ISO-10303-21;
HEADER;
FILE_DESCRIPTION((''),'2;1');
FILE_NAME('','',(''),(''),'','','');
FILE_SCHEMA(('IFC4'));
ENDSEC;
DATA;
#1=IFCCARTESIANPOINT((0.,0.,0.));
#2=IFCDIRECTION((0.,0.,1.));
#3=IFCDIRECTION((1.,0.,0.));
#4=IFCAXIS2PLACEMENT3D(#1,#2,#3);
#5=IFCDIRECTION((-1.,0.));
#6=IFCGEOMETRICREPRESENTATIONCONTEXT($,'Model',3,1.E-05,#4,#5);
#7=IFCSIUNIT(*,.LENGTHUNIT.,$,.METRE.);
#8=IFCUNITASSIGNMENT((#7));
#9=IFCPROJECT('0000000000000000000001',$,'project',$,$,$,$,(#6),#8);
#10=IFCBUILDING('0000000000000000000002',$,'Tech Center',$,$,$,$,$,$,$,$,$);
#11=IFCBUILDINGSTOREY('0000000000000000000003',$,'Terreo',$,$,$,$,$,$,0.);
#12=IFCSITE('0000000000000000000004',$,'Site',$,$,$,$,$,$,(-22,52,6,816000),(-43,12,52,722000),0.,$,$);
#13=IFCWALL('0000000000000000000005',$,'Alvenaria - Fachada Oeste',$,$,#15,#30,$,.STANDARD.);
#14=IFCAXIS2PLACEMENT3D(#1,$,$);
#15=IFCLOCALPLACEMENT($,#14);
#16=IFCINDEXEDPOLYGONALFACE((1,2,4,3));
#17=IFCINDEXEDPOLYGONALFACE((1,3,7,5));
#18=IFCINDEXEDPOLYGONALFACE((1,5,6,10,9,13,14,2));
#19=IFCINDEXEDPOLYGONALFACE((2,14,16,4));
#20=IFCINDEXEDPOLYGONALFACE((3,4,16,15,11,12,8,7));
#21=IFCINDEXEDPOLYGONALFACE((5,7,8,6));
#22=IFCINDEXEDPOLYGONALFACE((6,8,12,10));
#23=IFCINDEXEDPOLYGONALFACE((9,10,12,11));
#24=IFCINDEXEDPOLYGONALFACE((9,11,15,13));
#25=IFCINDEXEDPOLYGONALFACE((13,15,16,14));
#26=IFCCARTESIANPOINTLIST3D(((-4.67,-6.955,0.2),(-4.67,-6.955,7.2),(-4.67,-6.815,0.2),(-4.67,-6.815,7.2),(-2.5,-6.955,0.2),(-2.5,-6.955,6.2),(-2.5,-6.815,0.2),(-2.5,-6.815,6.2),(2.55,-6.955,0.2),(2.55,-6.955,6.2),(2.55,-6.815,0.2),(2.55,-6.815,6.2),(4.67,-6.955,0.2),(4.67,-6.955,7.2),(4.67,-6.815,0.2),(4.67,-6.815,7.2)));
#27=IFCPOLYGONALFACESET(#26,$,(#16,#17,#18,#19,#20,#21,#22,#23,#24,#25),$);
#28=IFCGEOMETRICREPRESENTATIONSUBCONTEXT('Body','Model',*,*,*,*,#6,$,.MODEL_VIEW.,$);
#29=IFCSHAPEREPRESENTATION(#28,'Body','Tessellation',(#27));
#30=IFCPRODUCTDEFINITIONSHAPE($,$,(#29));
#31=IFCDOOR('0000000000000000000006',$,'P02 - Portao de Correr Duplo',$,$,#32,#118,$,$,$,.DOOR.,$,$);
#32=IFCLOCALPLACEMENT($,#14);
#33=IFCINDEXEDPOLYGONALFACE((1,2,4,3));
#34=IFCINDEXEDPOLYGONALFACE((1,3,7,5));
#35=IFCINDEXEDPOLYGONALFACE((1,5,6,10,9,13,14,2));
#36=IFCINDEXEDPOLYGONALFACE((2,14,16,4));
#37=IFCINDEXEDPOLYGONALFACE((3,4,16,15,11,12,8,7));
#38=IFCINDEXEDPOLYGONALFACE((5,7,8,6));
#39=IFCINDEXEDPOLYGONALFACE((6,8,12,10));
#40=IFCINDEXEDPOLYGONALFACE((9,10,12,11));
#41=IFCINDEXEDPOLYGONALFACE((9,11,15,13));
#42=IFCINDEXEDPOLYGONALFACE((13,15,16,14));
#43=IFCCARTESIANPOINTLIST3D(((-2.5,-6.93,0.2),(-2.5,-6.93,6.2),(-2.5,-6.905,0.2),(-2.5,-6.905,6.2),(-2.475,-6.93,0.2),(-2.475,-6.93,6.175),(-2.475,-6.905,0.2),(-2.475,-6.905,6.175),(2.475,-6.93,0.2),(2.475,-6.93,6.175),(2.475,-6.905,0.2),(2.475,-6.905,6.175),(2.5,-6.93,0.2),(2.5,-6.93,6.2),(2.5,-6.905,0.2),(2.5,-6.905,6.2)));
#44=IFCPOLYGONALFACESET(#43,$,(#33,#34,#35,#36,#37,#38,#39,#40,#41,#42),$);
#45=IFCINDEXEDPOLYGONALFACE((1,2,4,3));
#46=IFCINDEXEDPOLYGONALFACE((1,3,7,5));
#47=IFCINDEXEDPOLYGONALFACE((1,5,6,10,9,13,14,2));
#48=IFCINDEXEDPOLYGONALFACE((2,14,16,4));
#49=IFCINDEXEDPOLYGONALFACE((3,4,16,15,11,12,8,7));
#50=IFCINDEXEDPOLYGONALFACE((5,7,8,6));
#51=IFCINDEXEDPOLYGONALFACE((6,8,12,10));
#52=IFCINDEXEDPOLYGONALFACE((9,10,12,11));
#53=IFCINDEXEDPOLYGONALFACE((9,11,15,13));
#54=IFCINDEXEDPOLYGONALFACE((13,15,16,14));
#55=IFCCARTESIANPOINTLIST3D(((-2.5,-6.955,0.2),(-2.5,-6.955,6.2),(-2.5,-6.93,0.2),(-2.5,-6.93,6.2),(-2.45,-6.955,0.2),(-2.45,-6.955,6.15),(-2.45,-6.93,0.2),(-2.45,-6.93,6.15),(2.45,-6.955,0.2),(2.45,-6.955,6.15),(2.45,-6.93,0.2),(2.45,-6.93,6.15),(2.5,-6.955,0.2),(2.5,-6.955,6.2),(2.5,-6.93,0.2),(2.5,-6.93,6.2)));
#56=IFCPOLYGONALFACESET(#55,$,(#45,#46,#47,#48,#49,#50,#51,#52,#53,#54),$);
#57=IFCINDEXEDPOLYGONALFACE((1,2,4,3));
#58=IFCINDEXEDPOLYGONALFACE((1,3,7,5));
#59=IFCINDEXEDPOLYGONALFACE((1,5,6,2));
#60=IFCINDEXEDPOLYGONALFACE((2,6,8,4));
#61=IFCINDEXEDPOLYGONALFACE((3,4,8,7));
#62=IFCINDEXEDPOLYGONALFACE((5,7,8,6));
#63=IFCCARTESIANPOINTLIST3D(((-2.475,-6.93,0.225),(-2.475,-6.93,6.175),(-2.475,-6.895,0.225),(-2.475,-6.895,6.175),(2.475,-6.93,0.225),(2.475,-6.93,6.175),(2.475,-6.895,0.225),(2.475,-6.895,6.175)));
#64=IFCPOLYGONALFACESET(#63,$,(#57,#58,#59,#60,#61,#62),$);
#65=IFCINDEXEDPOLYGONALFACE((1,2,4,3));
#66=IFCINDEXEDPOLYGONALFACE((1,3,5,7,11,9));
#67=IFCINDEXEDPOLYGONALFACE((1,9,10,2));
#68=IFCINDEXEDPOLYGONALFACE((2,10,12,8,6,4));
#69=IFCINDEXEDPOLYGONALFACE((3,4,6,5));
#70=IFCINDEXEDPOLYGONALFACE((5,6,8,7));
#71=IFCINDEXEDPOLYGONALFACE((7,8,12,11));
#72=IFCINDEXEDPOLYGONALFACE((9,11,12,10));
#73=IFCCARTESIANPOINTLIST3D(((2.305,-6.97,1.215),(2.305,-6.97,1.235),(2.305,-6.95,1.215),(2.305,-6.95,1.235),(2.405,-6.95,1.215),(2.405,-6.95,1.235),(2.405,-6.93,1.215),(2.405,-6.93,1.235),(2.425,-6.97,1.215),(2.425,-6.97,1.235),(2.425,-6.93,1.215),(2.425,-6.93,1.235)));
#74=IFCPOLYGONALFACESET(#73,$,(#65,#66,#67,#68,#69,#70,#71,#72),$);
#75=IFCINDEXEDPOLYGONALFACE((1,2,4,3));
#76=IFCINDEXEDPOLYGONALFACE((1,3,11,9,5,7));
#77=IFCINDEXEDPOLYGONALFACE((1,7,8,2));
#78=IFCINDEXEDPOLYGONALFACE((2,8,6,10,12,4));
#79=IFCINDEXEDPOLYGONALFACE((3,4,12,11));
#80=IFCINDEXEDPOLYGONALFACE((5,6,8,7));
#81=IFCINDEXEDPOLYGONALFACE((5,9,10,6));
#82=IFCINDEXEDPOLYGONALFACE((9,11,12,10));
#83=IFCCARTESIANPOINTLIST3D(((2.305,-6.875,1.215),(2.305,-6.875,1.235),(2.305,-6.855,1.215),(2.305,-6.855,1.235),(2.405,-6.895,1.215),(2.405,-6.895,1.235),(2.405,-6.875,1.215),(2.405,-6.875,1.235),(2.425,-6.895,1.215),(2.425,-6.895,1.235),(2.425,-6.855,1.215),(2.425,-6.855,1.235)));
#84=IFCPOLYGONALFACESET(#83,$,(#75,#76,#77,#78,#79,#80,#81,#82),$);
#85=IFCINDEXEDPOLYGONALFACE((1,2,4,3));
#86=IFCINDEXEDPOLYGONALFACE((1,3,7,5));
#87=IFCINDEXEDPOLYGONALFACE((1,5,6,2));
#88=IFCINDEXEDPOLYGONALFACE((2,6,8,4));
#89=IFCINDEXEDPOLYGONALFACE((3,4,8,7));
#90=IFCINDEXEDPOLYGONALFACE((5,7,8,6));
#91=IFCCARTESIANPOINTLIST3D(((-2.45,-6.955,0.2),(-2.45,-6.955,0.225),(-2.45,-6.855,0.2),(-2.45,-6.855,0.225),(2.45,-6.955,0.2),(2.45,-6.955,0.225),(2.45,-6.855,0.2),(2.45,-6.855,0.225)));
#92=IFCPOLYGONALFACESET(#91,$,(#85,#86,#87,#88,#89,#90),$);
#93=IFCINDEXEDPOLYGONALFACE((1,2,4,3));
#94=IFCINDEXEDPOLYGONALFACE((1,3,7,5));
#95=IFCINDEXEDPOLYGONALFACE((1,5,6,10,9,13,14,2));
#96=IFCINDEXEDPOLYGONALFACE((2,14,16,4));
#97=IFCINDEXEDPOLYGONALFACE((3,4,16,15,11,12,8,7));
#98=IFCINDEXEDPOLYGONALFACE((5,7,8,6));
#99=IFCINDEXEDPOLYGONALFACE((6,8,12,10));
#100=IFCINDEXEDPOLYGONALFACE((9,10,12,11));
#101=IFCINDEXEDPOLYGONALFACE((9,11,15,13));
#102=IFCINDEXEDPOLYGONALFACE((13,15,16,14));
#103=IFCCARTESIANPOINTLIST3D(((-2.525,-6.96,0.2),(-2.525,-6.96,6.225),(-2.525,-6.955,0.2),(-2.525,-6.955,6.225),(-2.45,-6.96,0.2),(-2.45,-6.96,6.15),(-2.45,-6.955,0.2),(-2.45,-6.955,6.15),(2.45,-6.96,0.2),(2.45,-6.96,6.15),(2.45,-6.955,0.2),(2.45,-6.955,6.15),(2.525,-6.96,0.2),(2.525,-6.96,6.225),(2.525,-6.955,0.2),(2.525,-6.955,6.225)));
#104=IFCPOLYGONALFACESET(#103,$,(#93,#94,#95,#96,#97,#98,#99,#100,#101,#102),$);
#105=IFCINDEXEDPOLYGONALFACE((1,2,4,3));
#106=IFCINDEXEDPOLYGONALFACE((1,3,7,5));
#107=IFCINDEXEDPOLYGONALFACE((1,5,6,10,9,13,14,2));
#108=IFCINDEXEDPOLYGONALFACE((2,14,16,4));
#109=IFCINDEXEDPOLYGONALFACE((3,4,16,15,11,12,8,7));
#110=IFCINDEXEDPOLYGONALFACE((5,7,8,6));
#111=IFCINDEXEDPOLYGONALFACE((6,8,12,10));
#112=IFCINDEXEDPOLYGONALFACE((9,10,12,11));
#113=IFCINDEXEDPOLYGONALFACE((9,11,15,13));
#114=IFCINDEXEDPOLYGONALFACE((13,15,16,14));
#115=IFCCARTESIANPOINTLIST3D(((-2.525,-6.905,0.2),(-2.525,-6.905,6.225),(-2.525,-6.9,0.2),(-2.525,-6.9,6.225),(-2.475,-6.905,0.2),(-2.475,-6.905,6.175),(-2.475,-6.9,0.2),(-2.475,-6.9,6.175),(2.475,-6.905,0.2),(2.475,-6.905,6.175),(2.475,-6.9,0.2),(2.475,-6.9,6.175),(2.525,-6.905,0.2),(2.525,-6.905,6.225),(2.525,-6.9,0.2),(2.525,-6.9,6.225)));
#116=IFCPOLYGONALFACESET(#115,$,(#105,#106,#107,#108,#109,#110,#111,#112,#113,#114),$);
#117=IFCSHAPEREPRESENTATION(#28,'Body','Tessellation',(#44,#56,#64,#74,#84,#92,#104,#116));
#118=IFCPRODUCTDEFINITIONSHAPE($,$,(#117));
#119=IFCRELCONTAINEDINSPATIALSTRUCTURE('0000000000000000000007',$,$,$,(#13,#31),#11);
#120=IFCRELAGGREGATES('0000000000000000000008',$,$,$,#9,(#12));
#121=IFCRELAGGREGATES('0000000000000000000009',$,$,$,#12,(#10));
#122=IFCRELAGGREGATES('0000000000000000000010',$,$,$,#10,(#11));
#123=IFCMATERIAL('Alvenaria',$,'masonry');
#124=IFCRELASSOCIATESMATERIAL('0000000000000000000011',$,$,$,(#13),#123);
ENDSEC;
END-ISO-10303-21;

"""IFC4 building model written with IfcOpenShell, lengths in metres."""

from ifc_helpers import new_model, si_unit, direction, frame, origin_with_axes, place, context, subcontext, project, spatial, line, indexed_curve, outline, extrude, material, element, fill, save


model = new_model("IFC4")

# Units and contexts
model_context = context("Model", 3, precision=1e-05, world=origin_with_axes(), true_north=direction((-1.0, 0.0)))
body_context = subcontext(model_context, "Body", "Model", "MODEL_VIEW")
ifc_project = project(units=[si_unit("LENGTHUNIT", "METRE")], contexts=[model_context])

# Site, building, storey
site = spatial("IfcSite", under=ifc_project, Name="Site", RefLatitude=(-22, 52, 6, 816000), RefLongitude=(-43, 12, 52, 722000), RefElevation=0.0)
building = spatial("IfcBuilding", under=site, Name="Tech Center")
storey = spatial("IfcBuildingStorey", under=building, Name="Terreo", Elevation=0.0)

# Wall, opening, door
ifc_material_1 = material(Name="Alvenaria", Category="masonry")
wall_1_placement = place(None, frame((-4.67, -6.955, 0.2), z_axis=(0.0, 0.0, 1.0), x_axis=(1.0, 0.0, 0.0)))
wall_1 = element("IfcWall", 1, at=wall_1_placement, inside=storey, material=ifc_material_1, Name="Alvenaria - Fachada Oeste", PredefinedType="STANDARD", context=body_context, shape_type="SweptSolid", body=[
    extrude(outline(indexed_curve([(0.0, 0.0), (0.0, 0.14), (9.34, 0.14), (9.34, 0.0), (0.0, 0.0)], self_intersect=False)), origin_with_axes(), (0.0, 0.0, 1.0), 7.0),
])
opening_1_placement = place(wall_1_placement, frame((2.17, 0.0, 0.0), z_axis=(0.0, 0.0, 1.0), x_axis=(1.0, 0.0, 0.0)))
opening_1 = element("IfcOpeningElement", 2, at=opening_1_placement, cuts=wall_1, context=body_context, shape_type="SweptSolid", body=[
    extrude(outline(indexed_curve([(0.0, 0.0), (0.0, 0.34), (5.05, 0.34), (5.05, 0.0), (0.0, 0.0)], self_intersect=False)), origin_with_axes(), (0.0, 0.0, 1.0), 6.0),
])
door_1_placement = place(None, frame((-2.5, -6.955, 0.2), z_axis=(0.0, 0.0, 1.0), x_axis=(1.0, 0.0, 0.0)))
door_1 = element("IfcDoor", 3, at=door_1_placement, inside=storey, Name="P02 - Portao de Correr Duplo", PredefinedType="DOOR", context=body_context, shape_type="SweptSolid", body=[
    extrude(outline(indexed_curve([(0.0, 0.0), (0.0, 6.0), (5.0, 6.0), (5.0, 0.0), (4.975, 0.0), (4.975, 5.975), (0.025, 5.975), (0.025, 0.0)], segments=[line(1, 2, 3, 4, 5, 6, 7, 8, 1)])), frame((0.0, 0.025, 0.0), z_axis=(0.0, -1.0, 0.0), x_axis=(1.0, 0.0, 0.0)), (0.0, 0.0, -1.0), 0.025),
    extrude(outline(indexed_curve([(0.0, 0.0), (0.0, 6.0), (5.0, 6.0), (5.0, 0.0), (4.95, 0.0), (4.95, 5.95), (0.05, 5.95), (0.05, 0.0)], segments=[line(1, 2, 3, 4, 5, 6, 7, 8, 1)])), frame((0.0, 0.0, 0.0), z_axis=(0.0, -1.0, 0.0), x_axis=(1.0, 0.0, 0.0)), (0.0, 0.0, -1.0), 0.025),
    extrude(outline(indexed_curve([(0.0, 0.0), (4.95, 0.0), (4.95, 0.035), (0.0, 0.035)], segments=[line(1, 2, 3, 4, 1)])), frame((0.025, 0.025, 0.025), z_axis=(0.0, 0.0, 1.0), x_axis=(1.0, 0.0, 0.0)), (0.0, 0.0, 1.0), 5.95),
    extrude(outline(indexed_curve([(0.0, 0.0), (0.0, -0.04), (-0.12, -0.04), (-0.12, -0.02), (-0.02, -0.02), (-0.02, 0.0)], segments=[line(1, 2, 3, 4, 5, 6, 1)])), frame((4.925, 0.025, 1.015), z_axis=(0.0, 0.0, 1.0), x_axis=(1.0, 0.0, 0.0)), (0.0, 0.0, 1.0), 0.02),
    extrude(outline(indexed_curve([(0.0, 0.0), (0.0, 0.04), (-0.12, 0.04), (-0.12, 0.02), (-0.02, 0.02), (-0.02, 0.0)], segments=[line(1, 2, 3, 4, 5, 6, 1)])), frame((4.925, 0.06, 1.015), z_axis=(0.0, 0.0, 1.0), x_axis=(1.0, 0.0, 0.0)), (0.0, 0.0, 1.0), 0.02),
    extrude(outline(indexed_curve([(0.0, 0.0), (4.9, 0.0), (4.9, 0.1), (0.0, 0.1)], segments=[line(1, 2, 3, 4, 1)])), frame((0.05, 0.0, 0.0), z_axis=(0.0, 0.0, 1.0), x_axis=(1.0, 0.0, 0.0)), (0.0, 0.0, 1.0), 0.025),
    extrude(outline(indexed_curve([(0.0, 0.0), (0.0, 6.025), (5.05, 6.025), (5.05, 0.0), (4.975, 0.0), (4.975, 5.95), (0.075, 5.95), (0.075, 0.0)], segments=[line(1, 2, 3, 4, 5, 6, 7, 8, 1)])), frame((-0.025, -0.005, 0.0), z_axis=(0.0, -1.0, 0.0), x_axis=(1.0, 0.0, 0.0)), (0.0, 0.0, -1.0), 0.005),
    extrude(outline(indexed_curve([(0.0, 0.0), (0.0, 6.025), (5.05, 6.025), (5.05, 0.0), (5.0, 0.0), (5.0, 5.975), (0.05, 5.975), (0.05, 0.0)], segments=[line(1, 2, 3, 4, 5, 6, 7, 8, 1)])), frame((-0.025, 0.05, 0.0), z_axis=(0.0, -1.0, 0.0), x_axis=(1.0, 0.0, 0.0)), (0.0, 0.0, -1.0), 0.005),
])
fill(opening_1, door_1)

save(model, "model.ifc")
